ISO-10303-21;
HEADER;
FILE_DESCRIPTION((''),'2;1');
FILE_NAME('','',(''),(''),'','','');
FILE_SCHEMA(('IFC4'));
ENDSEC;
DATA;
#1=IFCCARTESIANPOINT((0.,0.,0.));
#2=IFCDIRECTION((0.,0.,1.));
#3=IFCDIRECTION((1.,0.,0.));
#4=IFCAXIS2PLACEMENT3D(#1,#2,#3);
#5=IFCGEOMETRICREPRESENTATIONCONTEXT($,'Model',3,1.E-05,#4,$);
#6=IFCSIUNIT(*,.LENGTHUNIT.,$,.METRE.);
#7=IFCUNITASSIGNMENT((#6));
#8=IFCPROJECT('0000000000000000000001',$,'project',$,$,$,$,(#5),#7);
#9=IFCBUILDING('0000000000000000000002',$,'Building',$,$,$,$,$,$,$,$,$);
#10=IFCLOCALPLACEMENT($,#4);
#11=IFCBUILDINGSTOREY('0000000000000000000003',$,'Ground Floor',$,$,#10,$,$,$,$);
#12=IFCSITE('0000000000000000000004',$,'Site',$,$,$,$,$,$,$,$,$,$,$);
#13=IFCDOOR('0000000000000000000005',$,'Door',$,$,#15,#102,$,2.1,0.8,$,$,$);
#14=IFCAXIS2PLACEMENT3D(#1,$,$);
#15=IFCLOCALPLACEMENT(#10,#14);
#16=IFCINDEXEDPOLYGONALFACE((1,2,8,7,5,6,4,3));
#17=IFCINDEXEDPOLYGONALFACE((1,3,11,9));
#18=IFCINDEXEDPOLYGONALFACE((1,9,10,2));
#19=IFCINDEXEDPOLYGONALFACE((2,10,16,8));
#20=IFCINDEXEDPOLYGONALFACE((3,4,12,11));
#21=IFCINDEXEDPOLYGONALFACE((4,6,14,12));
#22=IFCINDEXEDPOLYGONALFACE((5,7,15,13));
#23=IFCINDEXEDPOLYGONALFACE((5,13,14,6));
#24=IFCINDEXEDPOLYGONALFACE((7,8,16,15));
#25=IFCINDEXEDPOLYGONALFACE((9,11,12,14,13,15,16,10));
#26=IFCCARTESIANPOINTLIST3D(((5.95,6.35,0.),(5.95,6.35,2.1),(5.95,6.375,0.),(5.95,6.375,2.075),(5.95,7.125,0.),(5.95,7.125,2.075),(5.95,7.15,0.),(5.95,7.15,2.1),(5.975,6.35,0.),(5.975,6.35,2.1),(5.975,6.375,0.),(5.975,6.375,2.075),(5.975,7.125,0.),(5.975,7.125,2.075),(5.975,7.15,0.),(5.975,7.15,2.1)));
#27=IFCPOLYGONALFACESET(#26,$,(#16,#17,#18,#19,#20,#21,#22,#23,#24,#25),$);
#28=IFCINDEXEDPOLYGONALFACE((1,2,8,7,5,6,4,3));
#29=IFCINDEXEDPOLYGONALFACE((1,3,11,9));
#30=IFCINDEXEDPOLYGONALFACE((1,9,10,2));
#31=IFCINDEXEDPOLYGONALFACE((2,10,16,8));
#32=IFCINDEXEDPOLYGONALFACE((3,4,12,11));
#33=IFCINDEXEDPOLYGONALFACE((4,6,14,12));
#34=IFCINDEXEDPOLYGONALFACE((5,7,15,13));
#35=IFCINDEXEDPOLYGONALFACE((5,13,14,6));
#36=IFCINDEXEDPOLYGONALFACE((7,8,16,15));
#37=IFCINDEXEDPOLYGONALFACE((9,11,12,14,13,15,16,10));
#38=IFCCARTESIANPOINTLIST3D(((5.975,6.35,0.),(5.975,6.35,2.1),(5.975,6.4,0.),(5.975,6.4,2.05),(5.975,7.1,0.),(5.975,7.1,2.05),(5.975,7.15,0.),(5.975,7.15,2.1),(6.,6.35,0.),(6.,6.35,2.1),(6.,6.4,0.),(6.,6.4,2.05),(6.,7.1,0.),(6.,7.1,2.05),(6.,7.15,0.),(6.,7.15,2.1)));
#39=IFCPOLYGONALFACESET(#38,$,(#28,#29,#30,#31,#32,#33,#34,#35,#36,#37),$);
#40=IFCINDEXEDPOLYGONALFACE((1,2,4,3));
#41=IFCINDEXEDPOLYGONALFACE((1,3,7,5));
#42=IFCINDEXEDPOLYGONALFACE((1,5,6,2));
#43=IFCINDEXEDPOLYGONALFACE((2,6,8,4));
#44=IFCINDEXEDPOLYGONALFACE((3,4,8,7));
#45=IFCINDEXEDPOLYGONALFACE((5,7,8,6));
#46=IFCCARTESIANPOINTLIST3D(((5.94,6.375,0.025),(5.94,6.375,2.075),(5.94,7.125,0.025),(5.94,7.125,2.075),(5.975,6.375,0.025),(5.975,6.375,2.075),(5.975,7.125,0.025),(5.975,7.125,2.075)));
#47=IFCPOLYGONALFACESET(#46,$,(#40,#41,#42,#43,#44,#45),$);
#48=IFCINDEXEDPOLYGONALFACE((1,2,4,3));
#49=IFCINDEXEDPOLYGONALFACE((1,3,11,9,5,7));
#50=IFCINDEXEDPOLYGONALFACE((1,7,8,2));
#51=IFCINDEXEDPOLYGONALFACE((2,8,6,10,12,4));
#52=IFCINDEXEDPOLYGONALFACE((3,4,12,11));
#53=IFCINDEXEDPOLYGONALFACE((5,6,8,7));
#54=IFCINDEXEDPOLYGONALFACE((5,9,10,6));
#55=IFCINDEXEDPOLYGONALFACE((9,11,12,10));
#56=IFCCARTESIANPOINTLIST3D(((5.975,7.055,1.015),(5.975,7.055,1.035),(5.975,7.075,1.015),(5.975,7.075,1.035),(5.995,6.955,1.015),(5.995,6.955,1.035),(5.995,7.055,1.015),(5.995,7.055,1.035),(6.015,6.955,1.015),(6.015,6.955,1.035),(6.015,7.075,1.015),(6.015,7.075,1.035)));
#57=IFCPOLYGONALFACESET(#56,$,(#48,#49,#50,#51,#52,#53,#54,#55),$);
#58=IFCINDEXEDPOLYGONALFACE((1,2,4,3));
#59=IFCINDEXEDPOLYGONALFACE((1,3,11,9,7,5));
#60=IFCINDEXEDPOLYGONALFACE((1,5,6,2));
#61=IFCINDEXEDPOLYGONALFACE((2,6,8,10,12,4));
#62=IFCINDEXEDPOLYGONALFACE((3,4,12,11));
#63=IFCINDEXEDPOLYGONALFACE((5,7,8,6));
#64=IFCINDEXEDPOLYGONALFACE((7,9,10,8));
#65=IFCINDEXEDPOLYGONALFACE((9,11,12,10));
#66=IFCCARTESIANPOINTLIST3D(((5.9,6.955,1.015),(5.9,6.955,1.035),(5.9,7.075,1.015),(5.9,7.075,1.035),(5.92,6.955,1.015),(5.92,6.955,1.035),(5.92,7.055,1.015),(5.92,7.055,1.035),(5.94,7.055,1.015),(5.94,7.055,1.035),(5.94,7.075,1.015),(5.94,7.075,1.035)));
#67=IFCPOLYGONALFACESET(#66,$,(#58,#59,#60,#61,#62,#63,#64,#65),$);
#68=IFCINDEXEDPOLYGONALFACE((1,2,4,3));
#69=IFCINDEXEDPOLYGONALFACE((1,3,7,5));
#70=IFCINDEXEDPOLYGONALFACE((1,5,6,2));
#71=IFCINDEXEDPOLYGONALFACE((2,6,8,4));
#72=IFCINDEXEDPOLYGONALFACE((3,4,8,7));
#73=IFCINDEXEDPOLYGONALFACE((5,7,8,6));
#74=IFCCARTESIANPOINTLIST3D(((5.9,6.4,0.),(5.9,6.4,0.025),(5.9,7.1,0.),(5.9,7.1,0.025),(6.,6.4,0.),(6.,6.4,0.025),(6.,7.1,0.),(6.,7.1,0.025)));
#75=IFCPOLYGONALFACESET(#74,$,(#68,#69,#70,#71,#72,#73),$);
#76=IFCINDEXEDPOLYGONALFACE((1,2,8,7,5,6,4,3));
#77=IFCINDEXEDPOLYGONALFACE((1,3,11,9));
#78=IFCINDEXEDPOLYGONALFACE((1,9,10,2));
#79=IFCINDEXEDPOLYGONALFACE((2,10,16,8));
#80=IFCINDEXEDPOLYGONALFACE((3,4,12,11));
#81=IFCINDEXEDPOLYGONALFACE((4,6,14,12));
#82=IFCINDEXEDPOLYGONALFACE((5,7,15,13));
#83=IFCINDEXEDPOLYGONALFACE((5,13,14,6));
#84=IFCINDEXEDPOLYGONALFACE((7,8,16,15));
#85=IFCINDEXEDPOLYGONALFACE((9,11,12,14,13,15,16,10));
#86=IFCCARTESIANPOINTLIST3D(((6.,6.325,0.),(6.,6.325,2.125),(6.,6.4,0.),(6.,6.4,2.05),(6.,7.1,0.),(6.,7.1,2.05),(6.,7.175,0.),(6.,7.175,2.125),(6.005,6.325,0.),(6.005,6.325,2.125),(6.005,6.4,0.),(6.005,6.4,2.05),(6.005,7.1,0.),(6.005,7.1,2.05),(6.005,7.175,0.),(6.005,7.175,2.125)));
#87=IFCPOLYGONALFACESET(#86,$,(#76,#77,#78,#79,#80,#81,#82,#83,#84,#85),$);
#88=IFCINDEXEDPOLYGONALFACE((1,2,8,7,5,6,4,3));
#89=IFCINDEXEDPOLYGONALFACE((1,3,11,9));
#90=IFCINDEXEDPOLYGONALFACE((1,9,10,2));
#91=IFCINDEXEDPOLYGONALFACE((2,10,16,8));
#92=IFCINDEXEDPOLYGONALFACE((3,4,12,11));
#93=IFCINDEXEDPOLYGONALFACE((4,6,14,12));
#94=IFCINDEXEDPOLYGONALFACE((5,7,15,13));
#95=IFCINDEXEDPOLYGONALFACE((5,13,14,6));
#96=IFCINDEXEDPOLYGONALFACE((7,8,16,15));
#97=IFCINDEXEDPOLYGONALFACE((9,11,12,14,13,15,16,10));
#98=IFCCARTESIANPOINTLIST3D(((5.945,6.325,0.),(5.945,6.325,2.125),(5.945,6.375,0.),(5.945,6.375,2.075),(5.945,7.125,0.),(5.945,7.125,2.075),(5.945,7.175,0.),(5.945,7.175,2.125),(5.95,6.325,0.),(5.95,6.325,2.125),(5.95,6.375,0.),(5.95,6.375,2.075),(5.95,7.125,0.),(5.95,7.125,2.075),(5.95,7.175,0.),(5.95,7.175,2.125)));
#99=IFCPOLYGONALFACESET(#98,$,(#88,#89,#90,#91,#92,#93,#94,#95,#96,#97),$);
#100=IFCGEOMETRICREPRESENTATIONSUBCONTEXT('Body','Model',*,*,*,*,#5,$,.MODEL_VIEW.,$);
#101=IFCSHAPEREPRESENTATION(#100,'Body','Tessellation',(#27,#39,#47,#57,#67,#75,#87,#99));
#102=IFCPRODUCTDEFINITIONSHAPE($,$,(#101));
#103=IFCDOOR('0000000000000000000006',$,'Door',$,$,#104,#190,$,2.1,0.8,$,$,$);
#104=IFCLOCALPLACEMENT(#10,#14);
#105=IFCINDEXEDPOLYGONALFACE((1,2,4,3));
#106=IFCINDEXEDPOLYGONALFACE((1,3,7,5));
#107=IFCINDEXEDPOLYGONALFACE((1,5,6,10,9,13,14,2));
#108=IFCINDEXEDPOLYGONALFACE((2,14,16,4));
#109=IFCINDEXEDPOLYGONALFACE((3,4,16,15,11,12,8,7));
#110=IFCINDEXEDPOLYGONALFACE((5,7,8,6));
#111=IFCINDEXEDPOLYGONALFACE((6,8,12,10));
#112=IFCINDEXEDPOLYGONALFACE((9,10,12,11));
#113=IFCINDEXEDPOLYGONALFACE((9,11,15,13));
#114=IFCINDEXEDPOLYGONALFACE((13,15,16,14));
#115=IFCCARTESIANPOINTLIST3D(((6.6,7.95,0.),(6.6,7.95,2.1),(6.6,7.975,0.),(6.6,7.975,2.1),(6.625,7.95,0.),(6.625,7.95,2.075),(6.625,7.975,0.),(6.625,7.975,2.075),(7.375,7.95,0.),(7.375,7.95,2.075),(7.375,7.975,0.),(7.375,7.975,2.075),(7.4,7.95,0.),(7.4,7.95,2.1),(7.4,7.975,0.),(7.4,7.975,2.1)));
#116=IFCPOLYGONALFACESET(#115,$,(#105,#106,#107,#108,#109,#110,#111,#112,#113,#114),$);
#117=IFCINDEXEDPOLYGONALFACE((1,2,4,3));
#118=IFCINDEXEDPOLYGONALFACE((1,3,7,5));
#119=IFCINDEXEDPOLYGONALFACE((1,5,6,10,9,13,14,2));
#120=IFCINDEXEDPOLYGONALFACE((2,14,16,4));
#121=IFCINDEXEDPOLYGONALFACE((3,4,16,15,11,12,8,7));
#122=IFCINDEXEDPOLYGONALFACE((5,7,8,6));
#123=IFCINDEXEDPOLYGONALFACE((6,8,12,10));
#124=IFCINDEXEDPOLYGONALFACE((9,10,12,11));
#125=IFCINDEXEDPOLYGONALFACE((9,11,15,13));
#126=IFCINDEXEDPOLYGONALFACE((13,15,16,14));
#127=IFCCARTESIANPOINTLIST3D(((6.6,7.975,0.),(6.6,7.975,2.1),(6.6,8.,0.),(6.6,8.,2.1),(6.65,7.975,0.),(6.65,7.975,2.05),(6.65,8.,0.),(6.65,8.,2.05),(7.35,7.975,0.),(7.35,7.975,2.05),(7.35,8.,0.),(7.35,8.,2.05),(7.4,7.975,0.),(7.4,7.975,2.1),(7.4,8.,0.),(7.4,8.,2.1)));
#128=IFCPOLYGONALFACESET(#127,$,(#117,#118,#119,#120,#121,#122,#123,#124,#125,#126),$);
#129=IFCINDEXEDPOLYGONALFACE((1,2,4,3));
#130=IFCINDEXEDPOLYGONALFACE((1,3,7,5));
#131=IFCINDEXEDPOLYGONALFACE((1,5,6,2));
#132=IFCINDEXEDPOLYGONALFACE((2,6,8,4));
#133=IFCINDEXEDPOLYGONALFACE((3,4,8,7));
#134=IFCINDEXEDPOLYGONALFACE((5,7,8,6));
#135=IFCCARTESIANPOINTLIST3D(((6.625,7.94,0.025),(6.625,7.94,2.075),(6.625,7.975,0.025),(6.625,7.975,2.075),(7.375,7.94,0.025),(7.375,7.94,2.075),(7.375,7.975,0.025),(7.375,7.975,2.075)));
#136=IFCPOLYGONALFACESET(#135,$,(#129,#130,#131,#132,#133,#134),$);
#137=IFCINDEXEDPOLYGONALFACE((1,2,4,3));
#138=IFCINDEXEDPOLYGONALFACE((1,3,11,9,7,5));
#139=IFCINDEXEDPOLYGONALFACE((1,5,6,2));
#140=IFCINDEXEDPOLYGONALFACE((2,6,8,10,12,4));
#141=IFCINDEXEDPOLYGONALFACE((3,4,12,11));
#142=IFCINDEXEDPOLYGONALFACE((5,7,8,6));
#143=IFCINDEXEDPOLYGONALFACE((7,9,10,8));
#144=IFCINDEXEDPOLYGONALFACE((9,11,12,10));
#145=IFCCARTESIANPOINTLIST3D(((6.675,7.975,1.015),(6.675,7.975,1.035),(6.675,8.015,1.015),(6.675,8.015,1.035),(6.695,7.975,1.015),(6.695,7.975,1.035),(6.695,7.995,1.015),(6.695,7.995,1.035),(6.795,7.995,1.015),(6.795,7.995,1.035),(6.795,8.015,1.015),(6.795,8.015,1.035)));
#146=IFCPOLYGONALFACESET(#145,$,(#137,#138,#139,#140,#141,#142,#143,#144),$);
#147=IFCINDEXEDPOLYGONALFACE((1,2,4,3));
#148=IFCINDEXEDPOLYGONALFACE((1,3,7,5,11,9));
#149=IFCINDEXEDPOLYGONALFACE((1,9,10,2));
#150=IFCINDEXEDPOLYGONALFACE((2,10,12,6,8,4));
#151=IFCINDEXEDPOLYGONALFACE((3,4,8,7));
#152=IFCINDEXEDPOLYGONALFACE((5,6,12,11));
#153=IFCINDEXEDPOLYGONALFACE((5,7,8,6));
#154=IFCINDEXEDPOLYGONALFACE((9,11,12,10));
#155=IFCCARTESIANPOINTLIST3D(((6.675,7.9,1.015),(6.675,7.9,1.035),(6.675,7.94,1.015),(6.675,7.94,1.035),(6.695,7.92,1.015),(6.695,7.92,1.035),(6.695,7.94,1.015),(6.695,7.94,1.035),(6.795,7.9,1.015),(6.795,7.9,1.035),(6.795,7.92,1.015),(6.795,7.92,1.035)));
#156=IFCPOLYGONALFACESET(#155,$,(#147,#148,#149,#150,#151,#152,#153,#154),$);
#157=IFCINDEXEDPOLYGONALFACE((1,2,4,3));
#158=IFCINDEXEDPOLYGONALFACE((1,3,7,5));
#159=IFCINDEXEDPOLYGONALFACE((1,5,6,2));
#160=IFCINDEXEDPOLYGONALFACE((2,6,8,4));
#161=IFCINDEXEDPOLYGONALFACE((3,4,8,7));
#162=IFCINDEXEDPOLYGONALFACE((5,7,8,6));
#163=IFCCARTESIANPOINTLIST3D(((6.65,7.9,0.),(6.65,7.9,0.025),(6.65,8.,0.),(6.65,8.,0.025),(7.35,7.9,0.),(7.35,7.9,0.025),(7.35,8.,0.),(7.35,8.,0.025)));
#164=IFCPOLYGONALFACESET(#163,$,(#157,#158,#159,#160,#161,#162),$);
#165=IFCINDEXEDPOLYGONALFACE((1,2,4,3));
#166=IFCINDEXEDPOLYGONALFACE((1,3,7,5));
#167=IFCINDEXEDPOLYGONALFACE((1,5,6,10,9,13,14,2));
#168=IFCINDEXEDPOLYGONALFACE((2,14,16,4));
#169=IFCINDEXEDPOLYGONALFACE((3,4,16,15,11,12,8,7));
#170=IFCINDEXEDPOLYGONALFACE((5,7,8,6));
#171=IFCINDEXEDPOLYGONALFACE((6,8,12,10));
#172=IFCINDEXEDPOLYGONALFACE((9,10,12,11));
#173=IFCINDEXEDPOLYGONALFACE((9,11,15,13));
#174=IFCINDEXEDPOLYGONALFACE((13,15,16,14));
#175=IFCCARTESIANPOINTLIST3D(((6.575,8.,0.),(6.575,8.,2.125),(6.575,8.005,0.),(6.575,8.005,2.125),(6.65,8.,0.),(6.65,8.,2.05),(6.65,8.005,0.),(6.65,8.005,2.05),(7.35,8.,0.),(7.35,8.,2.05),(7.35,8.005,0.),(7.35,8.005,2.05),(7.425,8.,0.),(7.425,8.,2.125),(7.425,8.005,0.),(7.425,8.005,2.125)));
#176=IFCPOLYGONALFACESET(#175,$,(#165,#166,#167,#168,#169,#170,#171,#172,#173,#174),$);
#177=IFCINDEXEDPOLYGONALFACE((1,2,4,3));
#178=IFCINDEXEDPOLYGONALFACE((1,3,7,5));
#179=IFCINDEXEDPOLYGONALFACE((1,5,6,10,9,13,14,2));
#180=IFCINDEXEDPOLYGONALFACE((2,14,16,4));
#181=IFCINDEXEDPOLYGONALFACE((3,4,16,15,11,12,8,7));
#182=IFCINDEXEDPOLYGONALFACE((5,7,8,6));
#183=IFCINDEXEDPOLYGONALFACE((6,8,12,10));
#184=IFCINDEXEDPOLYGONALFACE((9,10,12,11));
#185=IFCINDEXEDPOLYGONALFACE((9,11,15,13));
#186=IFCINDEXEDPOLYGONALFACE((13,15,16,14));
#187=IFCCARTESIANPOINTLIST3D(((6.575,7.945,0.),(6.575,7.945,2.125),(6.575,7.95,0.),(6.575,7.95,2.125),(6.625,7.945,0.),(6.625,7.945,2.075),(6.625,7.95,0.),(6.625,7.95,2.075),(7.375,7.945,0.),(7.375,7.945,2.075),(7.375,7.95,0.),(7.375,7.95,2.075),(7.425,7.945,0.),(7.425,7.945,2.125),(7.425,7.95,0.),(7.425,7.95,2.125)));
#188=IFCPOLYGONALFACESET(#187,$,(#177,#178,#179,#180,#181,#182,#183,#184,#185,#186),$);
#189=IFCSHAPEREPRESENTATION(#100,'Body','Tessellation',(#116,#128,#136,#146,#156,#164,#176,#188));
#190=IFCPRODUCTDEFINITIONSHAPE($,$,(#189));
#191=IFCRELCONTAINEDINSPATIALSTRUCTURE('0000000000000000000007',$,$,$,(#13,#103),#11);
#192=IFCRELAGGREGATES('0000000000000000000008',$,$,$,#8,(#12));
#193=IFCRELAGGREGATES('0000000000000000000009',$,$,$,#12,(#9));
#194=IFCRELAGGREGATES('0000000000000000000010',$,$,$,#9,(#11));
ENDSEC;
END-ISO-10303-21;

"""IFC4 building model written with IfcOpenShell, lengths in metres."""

from ifc_helpers import new_model, si_unit, frame, origin_with_axes, place, context, subcontext, project, spatial, line, indexed_curve, outline, extrude, element, save


model = new_model("IFC4")

# Units and contexts
model_context = context("Model", 3, precision=1e-05, world=origin_with_axes())
body_context = subcontext(model_context, "Body", "Model", "MODEL_VIEW")
ifc_project = project(units=[si_unit("LENGTHUNIT", "METRE")], contexts=[model_context])

# Site, building, storey
site = spatial("IfcSite", under=ifc_project, Name="Site")
building = spatial("IfcBuilding", under=site, Name="Building")
storey_placement = place(None, origin_with_axes())
storey = spatial("IfcBuildingStorey", under=building, at=storey_placement, Name="Ground Floor")

# Doors
door_1_placement = place(storey_placement, frame((6.0, 6.35, 0.0), z_axis=(0.0, 0.0, 1.0), x_axis=(0.0, 1.0, 0.0)))
element("IfcDoor", 1, at=door_1_placement, inside=storey, Name="Door", OverallHeight=2.1, OverallWidth=0.8, context=body_context, shape_type="SweptSolid", body=[
    extrude(outline(indexed_curve([(0.0, 0.0), (0.0, 2.1), (0.8, 2.1), (0.8, 0.0), (0.775, 0.0), (0.775, 2.075), (0.025, 2.075), (0.025, 0.0)], segments=[line(1, 2, 3, 4, 5, 6, 7, 8, 1)])), frame((0.0, 0.025, 0.0), z_axis=(0.0, -1.0, 0.0), x_axis=(1.0, 0.0, 0.0)), (0.0, 0.0, -1.0), 0.025),
    extrude(outline(indexed_curve([(0.0, 0.0), (0.0, 2.1), (0.8, 2.1), (0.8, 0.0), (0.75, 0.0), (0.75, 2.05), (0.05, 2.05), (0.05, 0.0)], segments=[line(1, 2, 3, 4, 5, 6, 7, 8, 1)])), frame((0.0, 0.0, 0.0), z_axis=(0.0, -1.0, 0.0), x_axis=(1.0, 0.0, 0.0)), (0.0, 0.0, -1.0), 0.025),
    extrude(outline(indexed_curve([(0.0, 0.0), (0.75, 0.0), (0.75, 0.035), (0.0, 0.035)], segments=[line(1, 2, 3, 4, 1)])), frame((0.025, 0.025, 0.025), z_axis=(0.0, 0.0, 1.0), x_axis=(1.0, 0.0, 0.0)), (0.0, 0.0, 1.0), 2.05),
    extrude(outline(indexed_curve([(0.0, 0.0), (0.0, -0.04), (-0.12, -0.04), (-0.12, -0.02), (-0.02, -0.02), (-0.02, 0.0)], segments=[line(1, 2, 3, 4, 5, 6, 1)])), frame((0.725, 0.025, 1.015), z_axis=(0.0, 0.0, 1.0), x_axis=(1.0, 0.0, 0.0)), (0.0, 0.0, 1.0), 0.02),
    extrude(outline(indexed_curve([(0.0, 0.0), (0.0, 0.04), (-0.12, 0.04), (-0.12, 0.02), (-0.02, 0.02), (-0.02, 0.0)], segments=[line(1, 2, 3, 4, 5, 6, 1)])), frame((0.725, 0.06, 1.015), z_axis=(0.0, 0.0, 1.0), x_axis=(1.0, 0.0, 0.0)), (0.0, 0.0, 1.0), 0.02),
    extrude(outline(indexed_curve([(0.0, 0.0), (0.7, 0.0), (0.7, 0.1), (0.0, 0.1)], segments=[line(1, 2, 3, 4, 1)])), frame((0.05, 0.0, 0.0), z_axis=(0.0, 0.0, 1.0), x_axis=(1.0, 0.0, 0.0)), (0.0, 0.0, 1.0), 0.025),
    extrude(outline(indexed_curve([(0.0, 0.0), (0.0, 2.125), (0.85, 2.125), (0.85, 0.0), (0.775, 0.0), (0.775, 2.05), (0.075, 2.05), (0.075, 0.0)], segments=[line(1, 2, 3, 4, 5, 6, 7, 8, 1)])), frame((-0.025, -0.005, 0.0), z_axis=(0.0, -1.0, 0.0), x_axis=(1.0, 0.0, 0.0)), (0.0, 0.0, -1.0), 0.005),
    extrude(outline(indexed_curve([(0.0, 0.0), (0.0, 2.125), (0.85, 2.125), (0.85, 0.0), (0.8, 0.0), (0.8, 2.075), (0.05, 2.075), (0.05, 0.0)], segments=[line(1, 2, 3, 4, 5, 6, 7, 8, 1)])), frame((-0.025, 0.05, 0.0), z_axis=(0.0, -1.0, 0.0), x_axis=(1.0, 0.0, 0.0)), (0.0, 0.0, -1.0), 0.005),
])
door_2_placement = place(storey_placement, frame((7.4, 8.0, 0.0), z_axis=(0.0, 0.0, 1.0), x_axis=(-1.0, 0.0, 0.0)))
element("IfcDoor", 2, at=door_2_placement, inside=storey, Name="Door", OverallHeight=2.1, OverallWidth=0.8, context=body_context, shape_type="SweptSolid", body=[
    extrude(outline(indexed_curve([(0.0, 0.0), (0.0, 2.1), (0.8, 2.1), (0.8, 0.0), (0.775, 0.0), (0.775, 2.075), (0.025, 2.075), (0.025, 0.0)], segments=[line(1, 2, 3, 4, 5, 6, 7, 8, 1)])), frame((0.0, 0.025, 0.0), z_axis=(0.0, -1.0, 0.0), x_axis=(1.0, 0.0, 0.0)), (0.0, 0.0, -1.0), 0.025),
    extrude(outline(indexed_curve([(0.0, 0.0), (0.0, 2.1), (0.8, 2.1), (0.8, 0.0), (0.75, 0.0), (0.75, 2.05), (0.05, 2.05), (0.05, 0.0)], segments=[line(1, 2, 3, 4, 5, 6, 7, 8, 1)])), frame((0.0, 0.0, 0.0), z_axis=(0.0, -1.0, 0.0), x_axis=(1.0, 0.0, 0.0)), (0.0, 0.0, -1.0), 0.025),
    extrude(outline(indexed_curve([(0.0, 0.0), (0.75, 0.0), (0.75, 0.035), (0.0, 0.035)], segments=[line(1, 2, 3, 4, 1)])), frame((0.025, 0.025, 0.025), z_axis=(0.0, 0.0, 1.0), x_axis=(1.0, 0.0, 0.0)), (0.0, 0.0, 1.0), 2.05),
    extrude(outline(indexed_curve([(0.0, 0.0), (0.0, -0.04), (-0.12, -0.04), (-0.12, -0.02), (-0.02, -0.02), (-0.02, 0.0)], segments=[line(1, 2, 3, 4, 5, 6, 1)])), frame((0.725, 0.025, 1.015), z_axis=(0.0, 0.0, 1.0), x_axis=(1.0, 0.0, 0.0)), (0.0, 0.0, 1.0), 0.02),
    extrude(outline(indexed_curve([(0.0, 0.0), (0.0, 0.04), (-0.12, 0.04), (-0.12, 0.02), (-0.02, 0.02), (-0.02, 0.0)], segments=[line(1, 2, 3, 4, 5, 6, 1)])), frame((0.725, 0.06, 1.015), z_axis=(0.0, 0.0, 1.0), x_axis=(1.0, 0.0, 0.0)), (0.0, 0.0, 1.0), 0.02),
    extrude(outline(indexed_curve([(0.0, 0.0), (0.7, 0.0), (0.7, 0.1), (0.0, 0.1)], segments=[line(1, 2, 3, 4, 1)])), frame((0.05, 0.0, 0.0), z_axis=(0.0, 0.0, 1.0), x_axis=(1.0, 0.0, 0.0)), (0.0, 0.0, 1.0), 0.025),
    extrude(outline(indexed_curve([(0.0, 0.0), (0.0, 2.125), (0.85, 2.125), (0.85, 0.0), (0.775, 0.0), (0.775, 2.05), (0.075, 2.05), (0.075, 0.0)], segments=[line(1, 2, 3, 4, 5, 6, 7, 8, 1)])), frame((-0.025, -0.005, 0.0), z_axis=(0.0, -1.0, 0.0), x_axis=(1.0, 0.0, 0.0)), (0.0, 0.0, -1.0), 0.005),
    extrude(outline(indexed_curve([(0.0, 0.0), (0.0, 2.125), (0.85, 2.125), (0.85, 0.0), (0.8, 0.0), (0.8, 2.075), (0.05, 2.075), (0.05, 0.0)], segments=[line(1, 2, 3, 4, 5, 6, 7, 8, 1)])), frame((-0.025, 0.05, 0.0), z_axis=(0.0, -1.0, 0.0), x_axis=(1.0, 0.0, 0.0)), (0.0, 0.0, -1.0), 0.005),
])

save(model, "model.ifc")
